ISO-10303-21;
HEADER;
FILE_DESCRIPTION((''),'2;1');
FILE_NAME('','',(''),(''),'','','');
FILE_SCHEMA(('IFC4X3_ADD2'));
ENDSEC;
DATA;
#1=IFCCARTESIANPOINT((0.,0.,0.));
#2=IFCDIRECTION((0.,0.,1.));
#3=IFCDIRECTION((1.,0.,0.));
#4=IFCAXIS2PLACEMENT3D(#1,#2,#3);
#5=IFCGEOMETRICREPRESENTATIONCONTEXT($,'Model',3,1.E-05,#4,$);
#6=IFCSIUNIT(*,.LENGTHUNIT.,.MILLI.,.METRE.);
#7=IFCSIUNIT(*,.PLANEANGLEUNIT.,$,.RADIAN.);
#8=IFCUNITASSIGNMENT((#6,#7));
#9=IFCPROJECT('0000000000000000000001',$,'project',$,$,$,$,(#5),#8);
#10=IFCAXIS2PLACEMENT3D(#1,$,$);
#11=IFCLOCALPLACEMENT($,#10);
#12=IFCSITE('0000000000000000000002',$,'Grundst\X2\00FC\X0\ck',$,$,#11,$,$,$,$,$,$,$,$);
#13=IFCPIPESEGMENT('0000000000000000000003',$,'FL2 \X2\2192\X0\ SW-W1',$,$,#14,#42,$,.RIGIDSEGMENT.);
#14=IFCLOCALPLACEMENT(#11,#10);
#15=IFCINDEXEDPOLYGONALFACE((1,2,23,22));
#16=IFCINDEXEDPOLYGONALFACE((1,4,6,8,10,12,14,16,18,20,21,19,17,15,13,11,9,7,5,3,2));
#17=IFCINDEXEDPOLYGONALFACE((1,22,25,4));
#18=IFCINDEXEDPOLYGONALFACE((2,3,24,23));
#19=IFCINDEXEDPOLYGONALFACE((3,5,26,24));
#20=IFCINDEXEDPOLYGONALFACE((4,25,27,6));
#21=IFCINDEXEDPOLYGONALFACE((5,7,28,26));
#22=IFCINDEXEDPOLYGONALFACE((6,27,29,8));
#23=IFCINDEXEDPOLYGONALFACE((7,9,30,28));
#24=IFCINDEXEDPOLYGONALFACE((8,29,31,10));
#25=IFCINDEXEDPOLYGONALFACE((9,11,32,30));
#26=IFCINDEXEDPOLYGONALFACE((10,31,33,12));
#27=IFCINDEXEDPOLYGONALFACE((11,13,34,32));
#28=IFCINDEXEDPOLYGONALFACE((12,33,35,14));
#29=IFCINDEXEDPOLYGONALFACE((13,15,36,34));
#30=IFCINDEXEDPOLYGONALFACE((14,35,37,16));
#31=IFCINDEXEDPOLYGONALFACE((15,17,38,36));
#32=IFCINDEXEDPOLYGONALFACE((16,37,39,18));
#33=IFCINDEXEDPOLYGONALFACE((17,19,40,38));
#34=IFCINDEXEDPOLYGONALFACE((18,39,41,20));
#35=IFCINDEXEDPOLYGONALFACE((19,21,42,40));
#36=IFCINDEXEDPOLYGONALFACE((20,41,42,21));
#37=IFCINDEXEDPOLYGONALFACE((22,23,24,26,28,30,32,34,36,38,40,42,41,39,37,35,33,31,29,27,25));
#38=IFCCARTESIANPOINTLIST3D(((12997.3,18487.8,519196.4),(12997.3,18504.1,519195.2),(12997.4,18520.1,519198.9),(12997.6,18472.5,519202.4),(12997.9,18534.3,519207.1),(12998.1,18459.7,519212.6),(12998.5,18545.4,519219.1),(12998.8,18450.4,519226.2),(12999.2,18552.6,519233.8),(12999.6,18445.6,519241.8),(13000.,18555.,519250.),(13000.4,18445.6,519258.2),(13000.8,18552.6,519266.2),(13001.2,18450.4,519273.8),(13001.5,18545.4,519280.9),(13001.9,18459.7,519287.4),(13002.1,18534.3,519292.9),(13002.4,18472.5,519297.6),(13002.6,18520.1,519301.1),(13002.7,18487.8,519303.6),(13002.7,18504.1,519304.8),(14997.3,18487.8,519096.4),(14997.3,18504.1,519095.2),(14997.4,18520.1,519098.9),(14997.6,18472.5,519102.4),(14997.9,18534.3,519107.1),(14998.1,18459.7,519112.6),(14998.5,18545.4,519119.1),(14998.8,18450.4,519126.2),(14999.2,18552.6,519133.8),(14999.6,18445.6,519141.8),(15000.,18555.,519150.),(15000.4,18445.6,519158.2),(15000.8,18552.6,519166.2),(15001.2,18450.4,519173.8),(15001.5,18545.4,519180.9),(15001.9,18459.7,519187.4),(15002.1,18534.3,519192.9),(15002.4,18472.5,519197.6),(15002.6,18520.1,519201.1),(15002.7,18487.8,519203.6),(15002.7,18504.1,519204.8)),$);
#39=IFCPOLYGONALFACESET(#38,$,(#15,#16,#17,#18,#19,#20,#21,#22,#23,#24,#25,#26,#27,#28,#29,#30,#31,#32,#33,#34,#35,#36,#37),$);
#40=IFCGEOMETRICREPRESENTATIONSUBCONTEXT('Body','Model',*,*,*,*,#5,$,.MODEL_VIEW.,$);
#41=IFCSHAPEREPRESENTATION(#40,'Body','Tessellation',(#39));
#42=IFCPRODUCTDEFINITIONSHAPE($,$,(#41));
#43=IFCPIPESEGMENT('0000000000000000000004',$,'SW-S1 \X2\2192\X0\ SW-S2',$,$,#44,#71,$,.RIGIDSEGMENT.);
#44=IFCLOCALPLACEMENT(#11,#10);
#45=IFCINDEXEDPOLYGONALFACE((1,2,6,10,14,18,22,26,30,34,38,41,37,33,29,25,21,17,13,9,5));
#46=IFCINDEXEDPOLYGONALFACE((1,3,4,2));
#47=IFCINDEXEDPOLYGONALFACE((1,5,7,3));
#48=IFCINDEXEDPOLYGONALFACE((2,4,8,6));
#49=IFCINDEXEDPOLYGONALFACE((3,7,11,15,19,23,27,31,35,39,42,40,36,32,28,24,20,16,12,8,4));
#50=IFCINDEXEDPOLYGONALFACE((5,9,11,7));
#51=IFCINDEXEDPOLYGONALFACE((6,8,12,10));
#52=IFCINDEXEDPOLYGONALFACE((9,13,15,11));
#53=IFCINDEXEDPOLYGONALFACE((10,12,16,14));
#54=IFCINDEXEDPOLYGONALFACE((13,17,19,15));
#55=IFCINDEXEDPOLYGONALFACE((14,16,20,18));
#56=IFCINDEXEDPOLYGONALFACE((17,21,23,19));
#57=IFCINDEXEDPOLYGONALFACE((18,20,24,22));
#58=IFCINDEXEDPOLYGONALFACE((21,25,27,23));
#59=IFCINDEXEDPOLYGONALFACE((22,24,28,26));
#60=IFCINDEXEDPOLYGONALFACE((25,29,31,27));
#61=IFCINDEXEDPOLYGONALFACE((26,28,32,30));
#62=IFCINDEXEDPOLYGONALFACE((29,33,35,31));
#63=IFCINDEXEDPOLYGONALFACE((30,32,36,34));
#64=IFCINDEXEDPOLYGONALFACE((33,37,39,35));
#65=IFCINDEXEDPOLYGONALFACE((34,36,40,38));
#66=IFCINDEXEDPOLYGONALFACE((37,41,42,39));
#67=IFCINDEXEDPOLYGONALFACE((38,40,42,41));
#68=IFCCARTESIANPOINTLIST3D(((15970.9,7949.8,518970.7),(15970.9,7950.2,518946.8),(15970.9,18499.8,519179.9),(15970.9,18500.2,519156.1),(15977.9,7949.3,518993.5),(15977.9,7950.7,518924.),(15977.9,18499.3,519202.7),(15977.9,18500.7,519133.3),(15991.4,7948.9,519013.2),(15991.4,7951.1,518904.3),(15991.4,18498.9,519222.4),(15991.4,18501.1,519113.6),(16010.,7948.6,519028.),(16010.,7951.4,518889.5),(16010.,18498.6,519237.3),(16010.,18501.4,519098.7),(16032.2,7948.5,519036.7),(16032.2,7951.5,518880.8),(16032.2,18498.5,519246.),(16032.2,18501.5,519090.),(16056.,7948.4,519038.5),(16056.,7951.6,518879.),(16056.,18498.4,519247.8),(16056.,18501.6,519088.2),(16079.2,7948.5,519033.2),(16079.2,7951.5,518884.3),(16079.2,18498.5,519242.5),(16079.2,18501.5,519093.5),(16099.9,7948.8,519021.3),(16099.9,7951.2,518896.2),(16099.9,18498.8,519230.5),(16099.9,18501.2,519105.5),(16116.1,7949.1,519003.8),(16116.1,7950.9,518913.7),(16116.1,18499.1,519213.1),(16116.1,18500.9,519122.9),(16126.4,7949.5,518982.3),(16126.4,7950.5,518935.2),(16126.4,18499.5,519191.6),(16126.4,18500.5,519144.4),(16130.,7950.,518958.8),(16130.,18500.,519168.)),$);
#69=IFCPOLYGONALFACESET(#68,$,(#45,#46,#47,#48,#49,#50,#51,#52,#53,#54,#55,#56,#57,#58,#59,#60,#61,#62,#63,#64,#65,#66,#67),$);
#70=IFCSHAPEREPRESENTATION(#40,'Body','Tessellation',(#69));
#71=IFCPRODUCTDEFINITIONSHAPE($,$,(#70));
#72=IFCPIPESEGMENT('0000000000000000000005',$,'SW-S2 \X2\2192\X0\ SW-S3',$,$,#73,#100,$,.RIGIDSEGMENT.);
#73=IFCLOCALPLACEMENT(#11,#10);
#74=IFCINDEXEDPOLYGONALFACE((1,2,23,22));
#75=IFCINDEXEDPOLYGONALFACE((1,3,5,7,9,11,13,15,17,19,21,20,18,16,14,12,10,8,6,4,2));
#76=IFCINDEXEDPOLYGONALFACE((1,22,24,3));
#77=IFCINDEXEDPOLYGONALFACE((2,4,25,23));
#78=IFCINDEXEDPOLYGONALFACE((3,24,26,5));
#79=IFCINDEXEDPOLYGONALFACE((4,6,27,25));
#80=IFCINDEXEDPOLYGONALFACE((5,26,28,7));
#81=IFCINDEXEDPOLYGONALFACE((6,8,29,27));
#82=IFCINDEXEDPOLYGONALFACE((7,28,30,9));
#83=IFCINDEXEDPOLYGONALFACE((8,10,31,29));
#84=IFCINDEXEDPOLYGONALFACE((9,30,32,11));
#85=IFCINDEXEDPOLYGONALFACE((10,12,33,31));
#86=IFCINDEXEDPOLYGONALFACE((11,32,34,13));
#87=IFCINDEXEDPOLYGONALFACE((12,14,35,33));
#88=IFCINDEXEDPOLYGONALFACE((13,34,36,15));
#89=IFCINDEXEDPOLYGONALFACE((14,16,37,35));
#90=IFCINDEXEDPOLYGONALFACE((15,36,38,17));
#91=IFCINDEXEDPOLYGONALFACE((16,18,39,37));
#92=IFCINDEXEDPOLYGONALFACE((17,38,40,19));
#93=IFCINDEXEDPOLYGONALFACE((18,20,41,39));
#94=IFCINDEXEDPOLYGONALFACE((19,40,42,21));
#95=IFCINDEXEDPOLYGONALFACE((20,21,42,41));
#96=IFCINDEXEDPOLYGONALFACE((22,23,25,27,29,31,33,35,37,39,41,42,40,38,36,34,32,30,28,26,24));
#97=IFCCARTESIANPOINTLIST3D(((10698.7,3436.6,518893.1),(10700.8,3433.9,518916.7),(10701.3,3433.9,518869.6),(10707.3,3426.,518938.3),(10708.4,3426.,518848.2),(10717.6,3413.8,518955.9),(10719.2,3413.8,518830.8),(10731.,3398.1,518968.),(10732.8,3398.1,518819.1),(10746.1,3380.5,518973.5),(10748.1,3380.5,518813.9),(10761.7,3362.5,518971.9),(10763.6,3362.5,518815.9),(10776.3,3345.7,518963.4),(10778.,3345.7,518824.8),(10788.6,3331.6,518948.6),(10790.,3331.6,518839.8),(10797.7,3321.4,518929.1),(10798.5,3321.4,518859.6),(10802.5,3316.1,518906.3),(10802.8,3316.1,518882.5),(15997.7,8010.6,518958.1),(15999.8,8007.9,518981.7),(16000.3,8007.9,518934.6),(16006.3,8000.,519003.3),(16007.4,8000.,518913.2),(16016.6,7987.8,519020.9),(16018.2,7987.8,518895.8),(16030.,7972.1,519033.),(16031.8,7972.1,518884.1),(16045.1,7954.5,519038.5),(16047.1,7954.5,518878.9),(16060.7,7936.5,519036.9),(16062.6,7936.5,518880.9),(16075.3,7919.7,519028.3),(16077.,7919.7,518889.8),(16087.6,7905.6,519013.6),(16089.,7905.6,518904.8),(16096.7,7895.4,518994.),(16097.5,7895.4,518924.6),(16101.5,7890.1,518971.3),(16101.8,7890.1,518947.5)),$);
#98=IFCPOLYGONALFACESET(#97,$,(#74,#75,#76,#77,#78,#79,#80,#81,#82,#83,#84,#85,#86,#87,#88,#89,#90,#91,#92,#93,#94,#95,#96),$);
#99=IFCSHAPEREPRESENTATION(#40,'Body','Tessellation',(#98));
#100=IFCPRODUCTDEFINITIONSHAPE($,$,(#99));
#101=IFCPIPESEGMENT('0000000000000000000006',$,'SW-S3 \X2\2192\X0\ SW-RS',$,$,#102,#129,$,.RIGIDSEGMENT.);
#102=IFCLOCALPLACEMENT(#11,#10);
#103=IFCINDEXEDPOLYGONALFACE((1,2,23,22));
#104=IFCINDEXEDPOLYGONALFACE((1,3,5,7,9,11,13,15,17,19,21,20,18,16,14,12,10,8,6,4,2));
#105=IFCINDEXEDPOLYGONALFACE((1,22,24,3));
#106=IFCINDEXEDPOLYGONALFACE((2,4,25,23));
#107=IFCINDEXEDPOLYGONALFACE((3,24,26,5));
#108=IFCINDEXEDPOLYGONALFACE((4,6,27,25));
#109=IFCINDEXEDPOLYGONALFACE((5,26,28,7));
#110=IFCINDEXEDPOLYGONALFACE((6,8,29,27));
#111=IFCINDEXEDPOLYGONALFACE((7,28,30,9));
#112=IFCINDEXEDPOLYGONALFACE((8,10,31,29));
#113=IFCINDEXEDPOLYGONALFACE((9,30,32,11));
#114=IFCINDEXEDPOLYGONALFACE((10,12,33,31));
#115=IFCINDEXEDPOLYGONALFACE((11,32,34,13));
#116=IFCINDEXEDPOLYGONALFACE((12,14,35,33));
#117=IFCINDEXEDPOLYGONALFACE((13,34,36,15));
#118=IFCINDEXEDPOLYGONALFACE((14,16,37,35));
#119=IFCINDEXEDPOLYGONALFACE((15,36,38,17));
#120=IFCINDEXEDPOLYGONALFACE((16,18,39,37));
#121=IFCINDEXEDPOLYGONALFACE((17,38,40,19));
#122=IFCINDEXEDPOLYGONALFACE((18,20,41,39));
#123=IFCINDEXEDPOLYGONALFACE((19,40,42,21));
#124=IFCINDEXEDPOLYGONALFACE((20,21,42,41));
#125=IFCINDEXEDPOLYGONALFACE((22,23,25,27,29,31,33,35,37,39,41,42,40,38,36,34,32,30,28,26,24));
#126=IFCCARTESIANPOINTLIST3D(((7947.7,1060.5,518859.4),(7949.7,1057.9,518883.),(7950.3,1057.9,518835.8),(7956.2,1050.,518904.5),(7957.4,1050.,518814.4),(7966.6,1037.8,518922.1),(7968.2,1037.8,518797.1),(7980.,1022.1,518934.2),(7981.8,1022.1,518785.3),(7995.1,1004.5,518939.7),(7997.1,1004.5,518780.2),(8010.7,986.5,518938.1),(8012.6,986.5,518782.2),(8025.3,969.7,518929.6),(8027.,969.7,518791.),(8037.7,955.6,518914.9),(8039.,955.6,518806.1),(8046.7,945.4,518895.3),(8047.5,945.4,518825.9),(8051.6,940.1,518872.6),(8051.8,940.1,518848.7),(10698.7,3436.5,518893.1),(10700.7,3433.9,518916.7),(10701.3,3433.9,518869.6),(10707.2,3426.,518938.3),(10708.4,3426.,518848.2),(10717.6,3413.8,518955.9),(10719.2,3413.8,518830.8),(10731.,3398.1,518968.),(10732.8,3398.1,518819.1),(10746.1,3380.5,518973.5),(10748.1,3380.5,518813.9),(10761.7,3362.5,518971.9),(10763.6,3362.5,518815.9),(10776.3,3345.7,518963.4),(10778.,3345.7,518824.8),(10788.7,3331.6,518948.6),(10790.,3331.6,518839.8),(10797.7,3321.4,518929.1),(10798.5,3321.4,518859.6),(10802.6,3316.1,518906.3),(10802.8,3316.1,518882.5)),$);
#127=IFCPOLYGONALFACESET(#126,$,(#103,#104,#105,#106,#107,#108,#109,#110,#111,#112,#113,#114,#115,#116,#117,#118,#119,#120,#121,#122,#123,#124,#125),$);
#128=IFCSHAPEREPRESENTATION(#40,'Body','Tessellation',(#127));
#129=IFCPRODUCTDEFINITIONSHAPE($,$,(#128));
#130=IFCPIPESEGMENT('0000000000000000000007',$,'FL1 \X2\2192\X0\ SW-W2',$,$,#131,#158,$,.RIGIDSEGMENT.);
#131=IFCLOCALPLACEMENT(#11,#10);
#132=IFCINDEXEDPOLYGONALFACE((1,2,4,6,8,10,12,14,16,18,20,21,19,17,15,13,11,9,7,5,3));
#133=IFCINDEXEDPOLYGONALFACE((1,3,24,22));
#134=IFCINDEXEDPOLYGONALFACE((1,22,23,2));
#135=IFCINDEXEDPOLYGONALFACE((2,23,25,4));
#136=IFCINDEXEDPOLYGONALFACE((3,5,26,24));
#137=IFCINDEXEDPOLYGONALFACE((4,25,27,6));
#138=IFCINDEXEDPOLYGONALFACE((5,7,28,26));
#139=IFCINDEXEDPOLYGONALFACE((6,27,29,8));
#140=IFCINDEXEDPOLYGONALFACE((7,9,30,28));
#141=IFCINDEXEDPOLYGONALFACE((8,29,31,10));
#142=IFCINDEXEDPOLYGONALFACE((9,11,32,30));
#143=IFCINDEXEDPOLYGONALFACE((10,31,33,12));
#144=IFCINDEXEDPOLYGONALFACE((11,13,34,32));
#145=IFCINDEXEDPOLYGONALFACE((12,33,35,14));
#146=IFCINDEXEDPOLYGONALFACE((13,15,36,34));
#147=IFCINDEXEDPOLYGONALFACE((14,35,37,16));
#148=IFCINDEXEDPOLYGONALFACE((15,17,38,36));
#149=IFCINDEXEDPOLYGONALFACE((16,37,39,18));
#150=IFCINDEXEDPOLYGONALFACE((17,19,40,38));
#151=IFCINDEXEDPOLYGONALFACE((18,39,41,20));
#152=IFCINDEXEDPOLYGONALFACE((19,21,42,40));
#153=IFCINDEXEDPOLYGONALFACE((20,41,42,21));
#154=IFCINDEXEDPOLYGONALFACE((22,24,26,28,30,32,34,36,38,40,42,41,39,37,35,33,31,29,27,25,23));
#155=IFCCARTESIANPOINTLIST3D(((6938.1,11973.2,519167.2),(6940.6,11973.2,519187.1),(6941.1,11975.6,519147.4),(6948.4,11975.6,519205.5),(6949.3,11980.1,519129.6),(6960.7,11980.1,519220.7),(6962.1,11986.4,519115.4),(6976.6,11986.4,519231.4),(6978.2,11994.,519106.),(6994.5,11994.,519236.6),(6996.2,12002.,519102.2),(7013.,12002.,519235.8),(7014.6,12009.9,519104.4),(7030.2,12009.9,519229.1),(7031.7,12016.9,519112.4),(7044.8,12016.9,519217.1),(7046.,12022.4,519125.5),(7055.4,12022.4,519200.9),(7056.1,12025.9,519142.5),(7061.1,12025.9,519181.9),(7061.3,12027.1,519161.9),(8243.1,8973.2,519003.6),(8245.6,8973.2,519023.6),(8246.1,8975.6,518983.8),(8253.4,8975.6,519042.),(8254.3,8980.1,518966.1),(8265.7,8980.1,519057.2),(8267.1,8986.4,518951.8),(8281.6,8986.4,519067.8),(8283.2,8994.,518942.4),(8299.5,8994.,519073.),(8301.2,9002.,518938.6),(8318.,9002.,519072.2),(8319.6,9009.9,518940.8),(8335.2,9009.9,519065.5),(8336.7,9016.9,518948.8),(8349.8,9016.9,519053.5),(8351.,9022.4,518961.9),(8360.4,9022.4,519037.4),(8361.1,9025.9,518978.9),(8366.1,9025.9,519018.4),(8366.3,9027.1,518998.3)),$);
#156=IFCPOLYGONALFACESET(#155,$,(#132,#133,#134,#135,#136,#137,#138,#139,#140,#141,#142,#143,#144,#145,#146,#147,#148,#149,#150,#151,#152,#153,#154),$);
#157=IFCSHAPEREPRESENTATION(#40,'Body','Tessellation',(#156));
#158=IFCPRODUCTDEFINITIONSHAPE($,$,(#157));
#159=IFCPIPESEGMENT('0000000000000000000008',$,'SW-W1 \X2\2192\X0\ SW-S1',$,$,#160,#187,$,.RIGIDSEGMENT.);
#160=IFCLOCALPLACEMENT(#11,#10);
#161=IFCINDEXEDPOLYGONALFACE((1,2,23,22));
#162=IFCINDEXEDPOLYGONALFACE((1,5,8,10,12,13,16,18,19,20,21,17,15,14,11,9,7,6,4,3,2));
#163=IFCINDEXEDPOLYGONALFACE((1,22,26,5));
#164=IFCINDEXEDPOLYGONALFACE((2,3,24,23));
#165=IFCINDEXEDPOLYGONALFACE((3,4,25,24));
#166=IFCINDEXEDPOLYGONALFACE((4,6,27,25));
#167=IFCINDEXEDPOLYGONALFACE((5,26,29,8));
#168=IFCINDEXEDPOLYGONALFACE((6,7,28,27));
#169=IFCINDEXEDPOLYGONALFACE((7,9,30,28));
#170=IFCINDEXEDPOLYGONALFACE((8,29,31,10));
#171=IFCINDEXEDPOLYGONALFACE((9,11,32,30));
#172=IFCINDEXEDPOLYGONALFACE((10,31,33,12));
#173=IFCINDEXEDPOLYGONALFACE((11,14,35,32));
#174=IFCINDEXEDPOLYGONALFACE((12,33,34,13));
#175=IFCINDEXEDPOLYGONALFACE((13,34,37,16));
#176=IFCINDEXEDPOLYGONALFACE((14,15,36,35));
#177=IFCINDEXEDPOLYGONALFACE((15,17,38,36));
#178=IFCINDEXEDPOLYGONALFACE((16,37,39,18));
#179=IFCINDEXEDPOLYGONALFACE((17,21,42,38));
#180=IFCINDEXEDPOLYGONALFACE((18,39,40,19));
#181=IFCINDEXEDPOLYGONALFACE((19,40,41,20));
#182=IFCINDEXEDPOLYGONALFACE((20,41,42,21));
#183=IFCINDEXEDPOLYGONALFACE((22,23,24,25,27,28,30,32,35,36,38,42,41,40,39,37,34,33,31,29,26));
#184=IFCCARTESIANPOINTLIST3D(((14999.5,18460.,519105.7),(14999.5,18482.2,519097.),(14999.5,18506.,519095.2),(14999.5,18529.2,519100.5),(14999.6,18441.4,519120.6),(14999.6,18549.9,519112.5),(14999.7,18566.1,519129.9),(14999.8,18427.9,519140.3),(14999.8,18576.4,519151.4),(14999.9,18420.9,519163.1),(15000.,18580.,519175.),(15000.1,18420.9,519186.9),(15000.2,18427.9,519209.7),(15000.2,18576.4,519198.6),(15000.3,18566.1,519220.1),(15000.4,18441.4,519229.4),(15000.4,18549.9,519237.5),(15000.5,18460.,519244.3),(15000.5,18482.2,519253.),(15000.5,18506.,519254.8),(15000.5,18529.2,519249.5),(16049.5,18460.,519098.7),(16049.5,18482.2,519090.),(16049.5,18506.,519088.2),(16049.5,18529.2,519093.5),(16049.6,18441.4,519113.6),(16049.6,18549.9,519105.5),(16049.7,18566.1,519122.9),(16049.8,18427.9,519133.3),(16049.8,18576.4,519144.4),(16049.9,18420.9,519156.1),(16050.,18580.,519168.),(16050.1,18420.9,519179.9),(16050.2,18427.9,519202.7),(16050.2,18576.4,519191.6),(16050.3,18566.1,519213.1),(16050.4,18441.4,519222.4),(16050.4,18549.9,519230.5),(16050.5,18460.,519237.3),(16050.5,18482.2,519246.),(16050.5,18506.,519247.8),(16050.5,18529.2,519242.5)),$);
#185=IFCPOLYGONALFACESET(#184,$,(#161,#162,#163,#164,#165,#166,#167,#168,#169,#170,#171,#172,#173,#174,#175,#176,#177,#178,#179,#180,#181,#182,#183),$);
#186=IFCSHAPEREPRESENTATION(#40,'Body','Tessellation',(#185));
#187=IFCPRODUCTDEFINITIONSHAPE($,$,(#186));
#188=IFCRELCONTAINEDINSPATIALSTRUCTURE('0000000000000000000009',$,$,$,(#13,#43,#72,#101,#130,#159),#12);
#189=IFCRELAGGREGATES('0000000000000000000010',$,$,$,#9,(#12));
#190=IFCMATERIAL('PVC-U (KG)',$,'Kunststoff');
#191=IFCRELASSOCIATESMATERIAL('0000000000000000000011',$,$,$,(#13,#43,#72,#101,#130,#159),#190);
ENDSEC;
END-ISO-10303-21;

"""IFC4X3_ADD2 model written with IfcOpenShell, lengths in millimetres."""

from ifc_helpers import new_model, si_unit, frame, origin, origin_with_axes, place, context, subcontext, project, spatial, circle, extrude, material, element, save


model = new_model("IFC4X3_ADD2")

# Units and contexts
model_context = context("Model", 3, precision=1e-05, world=origin_with_axes())
body_context = subcontext(model_context, "Body", "Model", "MODEL_VIEW")
ifc_project = project(units=[si_unit("LENGTHUNIT", "METRE", prefix="MILLI"), si_unit("PLANEANGLEUNIT", "RADIAN")], contexts=[model_context])

# Site
site_placement = place(None, origin())
site = spatial("IfcSite", under=ifc_project, at=site_placement, Name="Grundstück")

# Pipe segments
ifc_material = material(Name="PVC-U (KG)", Category="Kunststoff")
pipe_segment_1_placement = place(site_placement, frame((13000.0, 18500.0, 519195.0)))
element("IfcPipeSegment", 1, at=pipe_segment_1_placement, inside=site, material=ifc_material, Name="FL2 → SW-W1", PredefinedType="RIGIDSEGMENT", context=body_context, shape_type="SweptSolid", body=[
    extrude(circle(Radius=55.0), frame((0.0, 0.0, 55.0), z_axis=(0.998752, 0.0, -0.049938), x_axis=(0.0, 1.0, 0.0)), (0.0, 0.0, 1.0), 2002.5),
])
pipe_segment_2_placement = place(site_placement, frame((16050.0, 18500.0, 519088.0)))
element("IfcPipeSegment", 2, at=pipe_segment_2_placement, inside=site, material=ifc_material, Name="SW-S1 → SW-S2", PredefinedType="RIGIDSEGMENT", context=body_context, shape_type="SweptSolid", body=[
    extrude(circle(Radius=80.0), frame((0.0, 0.0, 80.0), z_axis=(0.0, -0.999803, -0.01983), x_axis=(1.0, 0.0, 0.0)), (0.0, 0.0, 1.0), 10552.1),
])
pipe_segment_3_placement = place(site_placement, frame((16050.0, 7950.0, 518878.8)))
element("IfcPipeSegment", 3, at=pipe_segment_3_placement, inside=site, material=ifc_material, Name="SW-S2 → SW-S3", PredefinedType="RIGIDSEGMENT", context=body_context, shape_type="SweptSolid", body=[
    extrude(circle(Radius=80.0), frame((0.0, 0.0, 80.0), z_axis=(-0.756961, -0.653395, -0.009283), x_axis=(0.0, 1.0, 0.0)), (0.0, 0.0, 1.0), 7000.4),
])
pipe_segment_4_placement = place(site_placement, frame((10751.0, 3376.0, 518813.8)))
element("IfcPipeSegment", 4, at=pipe_segment_4_placement, inside=site, material=ifc_material, Name="SW-S3 → SW-RS", PredefinedType="RIGIDSEGMENT", context=body_context, shape_type="SweptSolid", body=[
    extrude(circle(Radius=80.0), frame((0.0, 0.0, 80.0), z_axis=(-0.756772, -0.653613, -0.009288), x_axis=(0.0, 1.0, 0.0)), (0.0, 0.0, 1.0), 3635.2),
])
pipe_segment_5_placement = place(site_placement, frame((7000.0, 12000.0, 519102.1)))
element("IfcPipeSegment", 5, at=pipe_segment_5_placement, inside=site, material=ifc_material, Name="FL1 → SW-W2", PredefinedType="RIGIDSEGMENT", context=body_context, shape_type="SweptSolid", body=[
    extrude(circle(Radius=67.5), frame((0.0, 0.0, 67.5), z_axis=(0.398396, -0.915853, -0.049938), x_axis=(0.0, 1.0, 0.0)), (0.0, 0.0, 1.0), 3275.6),
])
pipe_segment_6_placement = place(site_placement, frame((15000.0, 18500.0, 519095.0)))
element("IfcPipeSegment", 6, at=pipe_segment_6_placement, inside=site, material=ifc_material, Name="SW-W1 → SW-S1", PredefinedType="RIGIDSEGMENT", context=body_context, shape_type="SweptSolid", body=[
    extrude(circle(Radius=80.0), frame((0.0, 0.0, 80.0), z_axis=(0.999978, 0.0, -0.006667), x_axis=(0.0, 1.0, 0.0)), (0.0, 0.0, 1.0), 1050.0),
])

save(model, "model.ifc")
